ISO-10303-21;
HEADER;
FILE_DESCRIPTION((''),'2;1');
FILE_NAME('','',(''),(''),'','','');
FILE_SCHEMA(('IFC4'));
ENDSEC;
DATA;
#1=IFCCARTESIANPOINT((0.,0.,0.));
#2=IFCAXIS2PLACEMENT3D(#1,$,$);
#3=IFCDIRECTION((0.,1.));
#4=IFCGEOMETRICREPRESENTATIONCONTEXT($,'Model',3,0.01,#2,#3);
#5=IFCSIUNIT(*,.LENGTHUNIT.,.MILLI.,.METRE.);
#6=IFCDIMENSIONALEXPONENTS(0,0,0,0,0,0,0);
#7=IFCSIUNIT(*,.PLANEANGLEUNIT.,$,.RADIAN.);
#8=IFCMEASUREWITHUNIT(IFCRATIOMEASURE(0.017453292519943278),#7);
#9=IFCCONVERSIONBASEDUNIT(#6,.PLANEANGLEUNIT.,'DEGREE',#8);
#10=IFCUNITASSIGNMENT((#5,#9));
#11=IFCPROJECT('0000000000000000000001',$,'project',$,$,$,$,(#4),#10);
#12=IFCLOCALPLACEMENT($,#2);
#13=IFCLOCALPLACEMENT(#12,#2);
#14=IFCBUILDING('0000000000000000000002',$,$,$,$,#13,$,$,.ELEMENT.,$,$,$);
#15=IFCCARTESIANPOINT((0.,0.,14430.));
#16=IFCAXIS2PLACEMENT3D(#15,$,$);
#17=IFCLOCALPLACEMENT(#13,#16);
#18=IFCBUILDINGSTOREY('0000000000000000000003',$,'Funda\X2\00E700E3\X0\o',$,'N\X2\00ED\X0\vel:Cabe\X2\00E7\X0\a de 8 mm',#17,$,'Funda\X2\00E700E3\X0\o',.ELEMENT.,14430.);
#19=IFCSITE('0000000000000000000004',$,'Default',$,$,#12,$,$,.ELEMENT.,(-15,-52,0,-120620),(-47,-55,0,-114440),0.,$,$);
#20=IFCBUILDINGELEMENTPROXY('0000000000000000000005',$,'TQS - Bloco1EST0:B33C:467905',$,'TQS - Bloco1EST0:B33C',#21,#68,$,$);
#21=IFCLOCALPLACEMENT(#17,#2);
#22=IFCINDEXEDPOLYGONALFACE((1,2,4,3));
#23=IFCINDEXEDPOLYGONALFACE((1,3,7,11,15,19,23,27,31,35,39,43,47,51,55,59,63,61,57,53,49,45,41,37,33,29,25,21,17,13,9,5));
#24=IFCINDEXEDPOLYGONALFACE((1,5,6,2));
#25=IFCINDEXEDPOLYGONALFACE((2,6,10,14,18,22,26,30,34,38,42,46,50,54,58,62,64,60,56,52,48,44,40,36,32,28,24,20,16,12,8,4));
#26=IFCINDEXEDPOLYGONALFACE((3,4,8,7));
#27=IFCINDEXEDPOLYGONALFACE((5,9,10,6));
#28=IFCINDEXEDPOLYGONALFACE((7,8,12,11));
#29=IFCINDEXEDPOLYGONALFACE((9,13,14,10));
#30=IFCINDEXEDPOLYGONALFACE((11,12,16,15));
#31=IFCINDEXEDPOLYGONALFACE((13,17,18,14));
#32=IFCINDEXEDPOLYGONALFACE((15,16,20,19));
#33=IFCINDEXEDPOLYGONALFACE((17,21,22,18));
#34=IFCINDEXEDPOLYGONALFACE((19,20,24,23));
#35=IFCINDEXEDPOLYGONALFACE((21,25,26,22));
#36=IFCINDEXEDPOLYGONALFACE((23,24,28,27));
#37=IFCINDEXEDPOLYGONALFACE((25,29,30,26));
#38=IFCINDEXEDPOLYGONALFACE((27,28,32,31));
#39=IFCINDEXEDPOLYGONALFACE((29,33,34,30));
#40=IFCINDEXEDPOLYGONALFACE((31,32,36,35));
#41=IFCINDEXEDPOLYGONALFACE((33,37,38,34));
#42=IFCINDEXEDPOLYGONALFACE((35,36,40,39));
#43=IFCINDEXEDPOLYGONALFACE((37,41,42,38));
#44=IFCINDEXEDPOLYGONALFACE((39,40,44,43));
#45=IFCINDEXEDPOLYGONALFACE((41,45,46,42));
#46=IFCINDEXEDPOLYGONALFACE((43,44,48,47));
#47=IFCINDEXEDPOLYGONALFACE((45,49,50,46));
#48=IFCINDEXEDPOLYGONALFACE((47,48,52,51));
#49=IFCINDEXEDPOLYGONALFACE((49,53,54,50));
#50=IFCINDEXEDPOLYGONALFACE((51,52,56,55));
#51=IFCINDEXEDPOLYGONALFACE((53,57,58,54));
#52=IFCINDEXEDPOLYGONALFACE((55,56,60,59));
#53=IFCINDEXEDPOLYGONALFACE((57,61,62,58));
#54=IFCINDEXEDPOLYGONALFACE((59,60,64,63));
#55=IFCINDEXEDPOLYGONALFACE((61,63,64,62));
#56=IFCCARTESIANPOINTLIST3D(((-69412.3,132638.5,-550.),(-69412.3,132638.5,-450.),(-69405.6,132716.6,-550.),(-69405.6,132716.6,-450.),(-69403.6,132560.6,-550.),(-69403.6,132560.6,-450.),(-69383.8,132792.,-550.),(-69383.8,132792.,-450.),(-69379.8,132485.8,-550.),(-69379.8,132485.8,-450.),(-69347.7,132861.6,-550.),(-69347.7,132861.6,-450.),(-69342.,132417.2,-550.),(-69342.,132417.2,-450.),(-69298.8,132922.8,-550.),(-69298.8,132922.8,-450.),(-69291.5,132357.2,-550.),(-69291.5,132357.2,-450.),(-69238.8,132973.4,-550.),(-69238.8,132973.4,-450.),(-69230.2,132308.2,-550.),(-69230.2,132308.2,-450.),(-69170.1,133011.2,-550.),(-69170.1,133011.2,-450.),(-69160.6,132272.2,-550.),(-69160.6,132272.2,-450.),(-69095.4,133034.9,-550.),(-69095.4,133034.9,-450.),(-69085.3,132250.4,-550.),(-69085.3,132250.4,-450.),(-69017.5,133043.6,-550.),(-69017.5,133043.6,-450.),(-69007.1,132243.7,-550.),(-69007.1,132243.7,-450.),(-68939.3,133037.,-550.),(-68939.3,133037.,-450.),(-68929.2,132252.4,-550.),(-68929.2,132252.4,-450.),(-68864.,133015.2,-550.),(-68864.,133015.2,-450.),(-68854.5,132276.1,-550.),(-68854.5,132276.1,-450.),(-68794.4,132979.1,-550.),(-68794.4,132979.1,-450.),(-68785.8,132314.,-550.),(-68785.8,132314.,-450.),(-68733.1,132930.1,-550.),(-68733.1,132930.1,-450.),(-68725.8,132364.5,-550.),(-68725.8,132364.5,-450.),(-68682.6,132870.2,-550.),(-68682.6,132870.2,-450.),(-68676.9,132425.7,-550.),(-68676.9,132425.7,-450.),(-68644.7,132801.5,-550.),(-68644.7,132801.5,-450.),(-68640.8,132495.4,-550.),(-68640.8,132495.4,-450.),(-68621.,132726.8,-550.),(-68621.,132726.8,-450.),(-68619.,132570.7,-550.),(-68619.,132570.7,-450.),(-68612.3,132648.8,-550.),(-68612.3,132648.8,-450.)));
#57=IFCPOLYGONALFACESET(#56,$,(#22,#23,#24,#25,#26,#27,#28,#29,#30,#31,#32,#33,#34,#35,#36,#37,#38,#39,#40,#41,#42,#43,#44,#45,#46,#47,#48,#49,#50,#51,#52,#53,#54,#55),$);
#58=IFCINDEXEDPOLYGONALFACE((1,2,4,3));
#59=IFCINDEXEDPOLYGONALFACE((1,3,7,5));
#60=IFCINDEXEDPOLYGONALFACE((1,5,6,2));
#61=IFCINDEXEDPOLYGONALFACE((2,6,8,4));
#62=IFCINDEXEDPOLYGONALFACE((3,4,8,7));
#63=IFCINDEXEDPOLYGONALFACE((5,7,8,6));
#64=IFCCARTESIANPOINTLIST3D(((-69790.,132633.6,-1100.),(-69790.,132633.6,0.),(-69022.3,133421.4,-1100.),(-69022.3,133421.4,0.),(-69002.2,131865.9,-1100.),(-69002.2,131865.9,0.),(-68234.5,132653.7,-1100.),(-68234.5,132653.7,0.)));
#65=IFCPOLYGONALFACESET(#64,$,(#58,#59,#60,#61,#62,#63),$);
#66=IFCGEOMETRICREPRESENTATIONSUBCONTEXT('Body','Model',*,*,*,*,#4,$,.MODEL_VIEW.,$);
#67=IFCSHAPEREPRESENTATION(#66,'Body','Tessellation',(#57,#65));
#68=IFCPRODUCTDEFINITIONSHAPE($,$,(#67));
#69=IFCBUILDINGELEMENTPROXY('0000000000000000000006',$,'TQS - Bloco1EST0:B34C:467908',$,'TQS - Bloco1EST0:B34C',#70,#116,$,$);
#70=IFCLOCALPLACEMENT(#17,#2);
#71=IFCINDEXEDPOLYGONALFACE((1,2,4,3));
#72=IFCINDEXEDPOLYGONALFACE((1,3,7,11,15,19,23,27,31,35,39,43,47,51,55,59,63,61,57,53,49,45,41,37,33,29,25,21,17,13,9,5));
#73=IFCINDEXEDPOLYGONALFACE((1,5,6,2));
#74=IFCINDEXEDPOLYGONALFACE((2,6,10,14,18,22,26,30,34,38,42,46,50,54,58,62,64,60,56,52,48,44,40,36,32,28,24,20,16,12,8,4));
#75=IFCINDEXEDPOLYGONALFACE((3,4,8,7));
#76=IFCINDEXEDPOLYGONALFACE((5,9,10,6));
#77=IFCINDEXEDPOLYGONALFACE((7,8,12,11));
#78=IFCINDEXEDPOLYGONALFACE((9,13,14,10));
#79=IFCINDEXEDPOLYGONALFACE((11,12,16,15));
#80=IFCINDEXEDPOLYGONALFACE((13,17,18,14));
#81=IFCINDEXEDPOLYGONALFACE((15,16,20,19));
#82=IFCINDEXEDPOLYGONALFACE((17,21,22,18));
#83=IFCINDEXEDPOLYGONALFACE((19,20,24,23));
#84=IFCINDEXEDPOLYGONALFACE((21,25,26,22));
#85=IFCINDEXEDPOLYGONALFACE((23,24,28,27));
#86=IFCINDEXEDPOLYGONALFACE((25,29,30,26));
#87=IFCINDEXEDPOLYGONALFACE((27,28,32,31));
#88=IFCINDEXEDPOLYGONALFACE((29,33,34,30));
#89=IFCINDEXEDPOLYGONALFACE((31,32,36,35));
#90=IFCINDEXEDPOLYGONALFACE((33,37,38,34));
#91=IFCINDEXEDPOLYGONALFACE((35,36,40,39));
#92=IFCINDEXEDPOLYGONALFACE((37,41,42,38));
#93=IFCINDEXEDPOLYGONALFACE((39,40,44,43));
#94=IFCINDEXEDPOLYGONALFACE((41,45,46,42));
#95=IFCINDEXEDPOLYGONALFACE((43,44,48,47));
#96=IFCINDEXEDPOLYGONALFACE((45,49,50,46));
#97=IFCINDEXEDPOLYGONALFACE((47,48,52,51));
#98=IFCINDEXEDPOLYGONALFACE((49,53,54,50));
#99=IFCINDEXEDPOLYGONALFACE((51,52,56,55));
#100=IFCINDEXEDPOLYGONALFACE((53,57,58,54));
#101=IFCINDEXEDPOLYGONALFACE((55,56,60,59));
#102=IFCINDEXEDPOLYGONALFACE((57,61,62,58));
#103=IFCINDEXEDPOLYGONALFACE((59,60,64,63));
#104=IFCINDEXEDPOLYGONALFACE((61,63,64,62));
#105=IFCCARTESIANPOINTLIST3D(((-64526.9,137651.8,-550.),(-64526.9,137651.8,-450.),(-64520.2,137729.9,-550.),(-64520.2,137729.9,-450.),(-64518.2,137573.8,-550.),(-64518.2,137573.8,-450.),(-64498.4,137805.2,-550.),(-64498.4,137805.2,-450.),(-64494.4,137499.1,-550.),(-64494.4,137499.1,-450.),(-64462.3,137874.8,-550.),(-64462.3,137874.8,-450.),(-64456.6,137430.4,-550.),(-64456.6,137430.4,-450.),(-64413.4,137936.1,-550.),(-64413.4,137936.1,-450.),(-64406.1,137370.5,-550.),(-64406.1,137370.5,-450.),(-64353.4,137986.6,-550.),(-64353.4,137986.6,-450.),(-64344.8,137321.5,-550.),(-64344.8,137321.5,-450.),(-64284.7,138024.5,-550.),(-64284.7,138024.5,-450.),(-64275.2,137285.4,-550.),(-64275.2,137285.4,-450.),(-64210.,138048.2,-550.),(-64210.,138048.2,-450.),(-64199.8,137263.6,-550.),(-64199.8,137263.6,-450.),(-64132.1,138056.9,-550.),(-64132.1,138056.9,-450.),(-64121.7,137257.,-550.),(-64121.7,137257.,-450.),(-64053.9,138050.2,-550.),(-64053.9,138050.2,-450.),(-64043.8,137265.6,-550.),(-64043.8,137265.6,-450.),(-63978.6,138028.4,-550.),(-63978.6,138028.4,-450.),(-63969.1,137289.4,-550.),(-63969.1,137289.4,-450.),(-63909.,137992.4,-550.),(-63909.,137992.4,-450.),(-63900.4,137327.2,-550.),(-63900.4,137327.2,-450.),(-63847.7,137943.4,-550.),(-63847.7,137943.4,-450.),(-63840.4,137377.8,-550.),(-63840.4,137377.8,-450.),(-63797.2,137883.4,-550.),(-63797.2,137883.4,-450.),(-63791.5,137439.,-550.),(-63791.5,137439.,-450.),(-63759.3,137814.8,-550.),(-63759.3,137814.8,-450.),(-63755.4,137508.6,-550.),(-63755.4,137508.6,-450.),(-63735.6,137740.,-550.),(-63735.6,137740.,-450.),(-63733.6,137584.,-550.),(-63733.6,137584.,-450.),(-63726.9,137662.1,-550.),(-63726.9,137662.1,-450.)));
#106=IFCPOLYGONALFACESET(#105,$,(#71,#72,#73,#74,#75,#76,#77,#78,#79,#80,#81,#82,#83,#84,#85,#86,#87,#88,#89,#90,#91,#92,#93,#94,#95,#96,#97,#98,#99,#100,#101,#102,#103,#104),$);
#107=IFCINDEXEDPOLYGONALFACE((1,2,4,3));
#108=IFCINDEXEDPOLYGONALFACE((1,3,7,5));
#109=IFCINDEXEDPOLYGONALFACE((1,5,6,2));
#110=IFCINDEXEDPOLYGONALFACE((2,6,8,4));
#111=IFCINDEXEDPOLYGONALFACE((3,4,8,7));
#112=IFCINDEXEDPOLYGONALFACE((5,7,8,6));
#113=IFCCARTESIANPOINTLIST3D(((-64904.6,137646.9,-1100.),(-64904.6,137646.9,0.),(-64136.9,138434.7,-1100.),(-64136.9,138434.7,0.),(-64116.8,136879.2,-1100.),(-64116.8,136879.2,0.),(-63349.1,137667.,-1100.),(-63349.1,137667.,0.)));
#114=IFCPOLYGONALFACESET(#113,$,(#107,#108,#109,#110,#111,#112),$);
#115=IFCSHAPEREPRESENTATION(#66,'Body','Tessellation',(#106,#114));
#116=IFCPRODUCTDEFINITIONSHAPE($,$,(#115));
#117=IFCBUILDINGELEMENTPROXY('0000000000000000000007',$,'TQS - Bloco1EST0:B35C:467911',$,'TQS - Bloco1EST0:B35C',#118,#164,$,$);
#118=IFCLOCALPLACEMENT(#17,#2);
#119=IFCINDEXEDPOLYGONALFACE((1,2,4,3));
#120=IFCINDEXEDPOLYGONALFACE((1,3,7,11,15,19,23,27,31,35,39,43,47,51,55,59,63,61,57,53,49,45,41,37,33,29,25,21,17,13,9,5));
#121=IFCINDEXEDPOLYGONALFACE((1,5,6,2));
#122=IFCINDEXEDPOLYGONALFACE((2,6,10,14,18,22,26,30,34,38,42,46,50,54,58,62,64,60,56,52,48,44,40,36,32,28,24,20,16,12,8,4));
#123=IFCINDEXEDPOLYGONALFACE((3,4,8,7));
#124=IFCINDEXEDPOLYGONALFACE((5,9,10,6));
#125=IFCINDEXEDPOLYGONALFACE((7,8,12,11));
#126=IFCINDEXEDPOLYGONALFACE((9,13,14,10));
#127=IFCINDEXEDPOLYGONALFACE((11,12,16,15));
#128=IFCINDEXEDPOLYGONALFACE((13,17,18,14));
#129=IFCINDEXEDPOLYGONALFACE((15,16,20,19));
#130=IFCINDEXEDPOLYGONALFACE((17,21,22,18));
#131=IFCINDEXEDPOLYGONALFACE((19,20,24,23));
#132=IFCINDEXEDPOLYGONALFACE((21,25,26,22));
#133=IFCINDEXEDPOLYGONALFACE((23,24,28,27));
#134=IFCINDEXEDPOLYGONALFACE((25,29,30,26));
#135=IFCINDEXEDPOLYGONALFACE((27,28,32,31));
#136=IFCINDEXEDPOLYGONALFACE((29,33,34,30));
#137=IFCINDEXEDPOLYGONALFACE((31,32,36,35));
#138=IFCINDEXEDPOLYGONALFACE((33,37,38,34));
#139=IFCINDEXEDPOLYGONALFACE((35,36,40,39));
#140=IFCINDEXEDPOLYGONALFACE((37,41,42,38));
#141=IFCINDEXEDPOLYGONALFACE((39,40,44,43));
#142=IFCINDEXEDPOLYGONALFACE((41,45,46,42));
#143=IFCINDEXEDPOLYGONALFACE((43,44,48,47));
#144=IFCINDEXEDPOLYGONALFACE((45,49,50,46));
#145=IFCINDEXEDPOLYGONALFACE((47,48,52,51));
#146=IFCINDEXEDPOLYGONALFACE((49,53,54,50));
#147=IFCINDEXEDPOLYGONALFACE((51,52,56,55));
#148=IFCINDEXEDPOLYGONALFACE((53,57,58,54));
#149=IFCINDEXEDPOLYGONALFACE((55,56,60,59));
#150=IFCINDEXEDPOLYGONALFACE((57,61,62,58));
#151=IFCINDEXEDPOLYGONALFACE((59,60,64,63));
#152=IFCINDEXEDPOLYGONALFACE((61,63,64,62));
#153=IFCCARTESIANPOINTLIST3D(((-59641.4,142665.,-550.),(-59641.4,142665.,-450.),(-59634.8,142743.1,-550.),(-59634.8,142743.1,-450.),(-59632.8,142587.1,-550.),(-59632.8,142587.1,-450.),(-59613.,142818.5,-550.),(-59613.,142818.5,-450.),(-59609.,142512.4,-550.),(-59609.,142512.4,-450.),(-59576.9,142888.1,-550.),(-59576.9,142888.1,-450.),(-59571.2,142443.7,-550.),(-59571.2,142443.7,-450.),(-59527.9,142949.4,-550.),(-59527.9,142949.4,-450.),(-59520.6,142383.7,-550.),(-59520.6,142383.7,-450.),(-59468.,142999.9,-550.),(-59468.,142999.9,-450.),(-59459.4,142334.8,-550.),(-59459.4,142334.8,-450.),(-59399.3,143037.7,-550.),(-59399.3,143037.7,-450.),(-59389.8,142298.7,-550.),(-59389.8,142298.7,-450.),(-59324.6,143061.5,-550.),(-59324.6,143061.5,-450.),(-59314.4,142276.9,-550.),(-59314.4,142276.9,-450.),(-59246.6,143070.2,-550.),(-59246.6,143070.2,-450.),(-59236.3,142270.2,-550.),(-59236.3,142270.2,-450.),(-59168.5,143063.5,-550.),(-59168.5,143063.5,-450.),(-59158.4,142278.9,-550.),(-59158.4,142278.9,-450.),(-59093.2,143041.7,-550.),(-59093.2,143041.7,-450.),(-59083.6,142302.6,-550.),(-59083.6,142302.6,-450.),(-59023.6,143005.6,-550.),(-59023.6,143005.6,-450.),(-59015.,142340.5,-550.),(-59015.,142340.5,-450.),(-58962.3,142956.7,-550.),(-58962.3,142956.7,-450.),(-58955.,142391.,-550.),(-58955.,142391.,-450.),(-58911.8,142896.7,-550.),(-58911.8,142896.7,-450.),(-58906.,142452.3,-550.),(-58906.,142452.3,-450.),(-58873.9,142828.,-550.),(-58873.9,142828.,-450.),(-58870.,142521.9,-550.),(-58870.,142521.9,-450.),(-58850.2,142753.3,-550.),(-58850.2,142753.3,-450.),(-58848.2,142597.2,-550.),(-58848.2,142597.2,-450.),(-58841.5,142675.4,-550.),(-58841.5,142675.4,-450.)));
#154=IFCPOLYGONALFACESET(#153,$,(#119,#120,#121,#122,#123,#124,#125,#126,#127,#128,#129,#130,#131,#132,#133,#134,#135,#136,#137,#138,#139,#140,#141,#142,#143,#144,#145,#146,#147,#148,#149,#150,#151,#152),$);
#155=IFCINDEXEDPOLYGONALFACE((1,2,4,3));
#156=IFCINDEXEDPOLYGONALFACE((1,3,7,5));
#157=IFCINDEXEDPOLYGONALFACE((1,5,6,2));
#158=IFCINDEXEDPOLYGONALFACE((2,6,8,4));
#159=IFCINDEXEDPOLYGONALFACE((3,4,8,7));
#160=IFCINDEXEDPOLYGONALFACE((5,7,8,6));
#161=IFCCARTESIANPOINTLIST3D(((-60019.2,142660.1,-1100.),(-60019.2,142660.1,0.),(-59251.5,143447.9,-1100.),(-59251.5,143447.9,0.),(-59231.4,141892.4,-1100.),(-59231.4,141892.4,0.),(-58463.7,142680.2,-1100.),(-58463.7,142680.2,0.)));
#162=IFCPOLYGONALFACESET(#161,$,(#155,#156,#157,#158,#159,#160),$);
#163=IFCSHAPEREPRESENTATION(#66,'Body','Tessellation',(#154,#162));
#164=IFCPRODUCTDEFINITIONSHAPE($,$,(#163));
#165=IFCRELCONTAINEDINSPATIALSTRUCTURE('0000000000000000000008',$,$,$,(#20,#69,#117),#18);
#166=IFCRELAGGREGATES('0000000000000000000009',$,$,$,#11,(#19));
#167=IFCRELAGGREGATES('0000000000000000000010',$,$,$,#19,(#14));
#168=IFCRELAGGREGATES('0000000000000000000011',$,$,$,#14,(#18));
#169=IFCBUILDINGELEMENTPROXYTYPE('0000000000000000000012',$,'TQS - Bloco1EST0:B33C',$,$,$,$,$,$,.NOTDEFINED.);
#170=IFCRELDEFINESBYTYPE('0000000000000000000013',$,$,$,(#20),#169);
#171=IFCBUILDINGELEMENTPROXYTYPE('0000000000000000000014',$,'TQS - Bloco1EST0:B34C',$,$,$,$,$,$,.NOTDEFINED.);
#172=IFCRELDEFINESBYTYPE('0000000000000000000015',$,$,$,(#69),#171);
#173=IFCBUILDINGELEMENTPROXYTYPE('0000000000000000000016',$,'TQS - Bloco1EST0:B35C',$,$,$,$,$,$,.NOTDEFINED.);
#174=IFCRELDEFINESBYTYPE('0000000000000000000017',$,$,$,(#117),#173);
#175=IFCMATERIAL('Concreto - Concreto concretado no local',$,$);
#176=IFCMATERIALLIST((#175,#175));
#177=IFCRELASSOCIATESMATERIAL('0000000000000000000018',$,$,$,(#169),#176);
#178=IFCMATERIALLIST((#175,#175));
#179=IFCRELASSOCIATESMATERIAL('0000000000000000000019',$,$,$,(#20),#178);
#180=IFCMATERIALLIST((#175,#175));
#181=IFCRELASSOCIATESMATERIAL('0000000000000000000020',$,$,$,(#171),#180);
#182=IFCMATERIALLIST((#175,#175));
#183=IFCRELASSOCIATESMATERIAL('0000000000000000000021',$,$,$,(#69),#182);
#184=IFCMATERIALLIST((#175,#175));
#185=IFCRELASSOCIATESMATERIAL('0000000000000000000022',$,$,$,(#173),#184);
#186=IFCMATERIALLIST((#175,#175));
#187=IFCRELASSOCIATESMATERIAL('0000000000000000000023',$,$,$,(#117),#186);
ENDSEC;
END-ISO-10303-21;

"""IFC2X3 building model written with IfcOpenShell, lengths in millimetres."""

from ifc_helpers import new_model, entity, si_unit, converted_unit, direction, frame, frame_2d, origin, origin_2d_with_axis, place, context, subcontext, project, spatial, rectangle, circle, extrude, source, transform, mapped, material, material_list, type_object, type_shapes, element, save


model = new_model("IFC2X3")

# Units and contexts
model_context = context("Model", 3, precision=0.01, world=origin(), true_north=direction((0.0, 1.0)))
body_context = subcontext(model_context, "Body", "Model", "MODEL_VIEW")
ifc_project = project(units=[si_unit("LENGTHUNIT", "METRE", prefix="MILLI"), converted_unit("PLANEANGLEUNIT", "DEGREE", entity("IfcRatioMeasure", 0.017453292519943278), si_unit("PLANEANGLEUNIT", "RADIAN"), dimensions=[0, 0, 0, 0, 0, 0, 0])], contexts=[model_context])

# Site, building, storey
site_placement = place(None, origin())
site = spatial("IfcSite", under=ifc_project, at=site_placement, Name="Default", CompositionType="ELEMENT", RefLatitude=(-15, -52, 0, -120620), RefLongitude=(-47, -55, 0, -114440), RefElevation=0.0)
building_placement = place(site_placement, origin())
building = spatial("IfcBuilding", under=site, at=building_placement, CompositionType="ELEMENT")
storey_placement = place(building_placement, frame((0.0, 0.0, 14430.0)))
storey = spatial("IfcBuildingStorey", under=building, at=storey_placement, Name="Fundação", ObjectType="Nível:Cabeça de 8 mm", LongName="Fundação", CompositionType="ELEMENT", Elevation=14430.0)

# Building element proxies
ifc_material_1 = material(Name="Concreto - Concreto concretado no local")
ifc_material_list_1 = material_list([ifc_material_1, ifc_material_1])
ifc_material_list_2 = material_list([ifc_material_1, ifc_material_1])
building_element_proxy_type_1 = type_object("IfcBuildingElementProxyType", Name="TQS - Bloco1EST0:B33C", PredefinedType="NOTDEFINED", material=ifc_material_list_2)
shared_shape_1 = source(origin(), body_context, "Body", "SweptSolid", [
    extrude(circle(Radius=400.0, at=frame_2d((0.0, 0.0), x_axis=(1.0, 0.0))), frame((0.0, 0.0, -550.0)), (0.0, 0.0, 1.0), 100.0),
    extrude(rectangle(XDim=1100.0, YDim=1100.0, at=origin_2d_with_axis()), frame((0.0, 0.0, -1100.0), z_axis=(0.0, 0.0, 1.0), x_axis=(-1.0, 0.0, 0.0)), (0.0, 0.0, 1.0), 1100.0),
])
type_shapes(building_element_proxy_type_1, [shared_shape_1])
proxy_1_placement = place(storey_placement, frame((-69012.3, 132643.7, 0.0), z_axis=(0.0, 0.0, 1.0), x_axis=(0.697915, 0.71618, 0.0)))
element("IfcBuildingElementProxy", 1, at=proxy_1_placement, inside=storey, type_object=building_element_proxy_type_1, material=ifc_material_list_1, Name="TQS - Bloco1EST0:B33C:467905", ObjectType="TQS - Bloco1EST0:B33C", context=body_context, shape_type="MappedRepresentation", body=[
    mapped(shared_shape_1, transform((0.0, 0.0, 0.0), scale=1.0)),
])
ifc_material_list_3 = material_list([ifc_material_1, ifc_material_1])
ifc_material_list_4 = material_list([ifc_material_1, ifc_material_1])
building_element_proxy_type_2 = type_object("IfcBuildingElementProxyType", Name="TQS - Bloco1EST0:B34C", PredefinedType="NOTDEFINED", material=ifc_material_list_4)
shared_shape_2 = source(origin(), body_context, "Body", "SweptSolid", [
    extrude(circle(Radius=400.0, at=frame_2d((0.0, 0.0), x_axis=(1.0, 0.0))), frame((0.0, 0.0, -550.0)), (0.0, 0.0, 1.0), 100.0),
    extrude(rectangle(XDim=1100.0, YDim=1100.0, at=origin_2d_with_axis()), frame((0.0, 0.0, -1100.0), z_axis=(0.0, 0.0, 1.0), x_axis=(-1.0, 0.0, 0.0)), (0.0, 0.0, 1.0), 1100.0),
])
type_shapes(building_element_proxy_type_2, [shared_shape_2])
proxy_2_placement = place(storey_placement, frame((-64126.9, 137656.9, 0.0), z_axis=(0.0, 0.0, 1.0), x_axis=(0.697915, 0.71618, 0.0)))
element("IfcBuildingElementProxy", 2, at=proxy_2_placement, inside=storey, type_object=building_element_proxy_type_2, material=ifc_material_list_3, Name="TQS - Bloco1EST0:B34C:467908", ObjectType="TQS - Bloco1EST0:B34C", context=body_context, shape_type="MappedRepresentation", body=[
    mapped(shared_shape_2, transform((0.0, 0.0, 0.0), scale=1.0)),
])
ifc_material_list_5 = material_list([ifc_material_1, ifc_material_1])
ifc_material_list_6 = material_list([ifc_material_1, ifc_material_1])
building_element_proxy_type_3 = type_object("IfcBuildingElementProxyType", Name="TQS - Bloco1EST0:B35C", PredefinedType="NOTDEFINED", material=ifc_material_list_6)
shared_shape_3 = source(origin(), body_context, "Body", "SweptSolid", [
    extrude(circle(Radius=400.0, at=frame_2d((0.0, 0.0), x_axis=(1.0, 0.0))), frame((0.0, 0.0, -550.0)), (0.0, 0.0, 1.0), 100.0),
    extrude(rectangle(XDim=1100.0, YDim=1100.0, at=origin_2d_with_axis()), frame((0.0, 0.0, -1100.0), z_axis=(0.0, 0.0, 1.0), x_axis=(-1.0, 0.0, 0.0)), (0.0, 0.0, 1.0), 1100.0),
])
type_shapes(building_element_proxy_type_3, [shared_shape_3])
proxy_3_placement = place(storey_placement, frame((-59241.5, 142670.2, 0.0), z_axis=(0.0, 0.0, 1.0), x_axis=(0.697915, 0.71618, 0.0)))
element("IfcBuildingElementProxy", 3, at=proxy_3_placement, inside=storey, type_object=building_element_proxy_type_3, material=ifc_material_list_5, Name="TQS - Bloco1EST0:B35C:467911", ObjectType="TQS - Bloco1EST0:B35C", context=body_context, shape_type="MappedRepresentation", body=[
    mapped(shared_shape_3, transform((0.0, 0.0, 0.0), scale=1.0)),
])

save(model, "model.ifc")
